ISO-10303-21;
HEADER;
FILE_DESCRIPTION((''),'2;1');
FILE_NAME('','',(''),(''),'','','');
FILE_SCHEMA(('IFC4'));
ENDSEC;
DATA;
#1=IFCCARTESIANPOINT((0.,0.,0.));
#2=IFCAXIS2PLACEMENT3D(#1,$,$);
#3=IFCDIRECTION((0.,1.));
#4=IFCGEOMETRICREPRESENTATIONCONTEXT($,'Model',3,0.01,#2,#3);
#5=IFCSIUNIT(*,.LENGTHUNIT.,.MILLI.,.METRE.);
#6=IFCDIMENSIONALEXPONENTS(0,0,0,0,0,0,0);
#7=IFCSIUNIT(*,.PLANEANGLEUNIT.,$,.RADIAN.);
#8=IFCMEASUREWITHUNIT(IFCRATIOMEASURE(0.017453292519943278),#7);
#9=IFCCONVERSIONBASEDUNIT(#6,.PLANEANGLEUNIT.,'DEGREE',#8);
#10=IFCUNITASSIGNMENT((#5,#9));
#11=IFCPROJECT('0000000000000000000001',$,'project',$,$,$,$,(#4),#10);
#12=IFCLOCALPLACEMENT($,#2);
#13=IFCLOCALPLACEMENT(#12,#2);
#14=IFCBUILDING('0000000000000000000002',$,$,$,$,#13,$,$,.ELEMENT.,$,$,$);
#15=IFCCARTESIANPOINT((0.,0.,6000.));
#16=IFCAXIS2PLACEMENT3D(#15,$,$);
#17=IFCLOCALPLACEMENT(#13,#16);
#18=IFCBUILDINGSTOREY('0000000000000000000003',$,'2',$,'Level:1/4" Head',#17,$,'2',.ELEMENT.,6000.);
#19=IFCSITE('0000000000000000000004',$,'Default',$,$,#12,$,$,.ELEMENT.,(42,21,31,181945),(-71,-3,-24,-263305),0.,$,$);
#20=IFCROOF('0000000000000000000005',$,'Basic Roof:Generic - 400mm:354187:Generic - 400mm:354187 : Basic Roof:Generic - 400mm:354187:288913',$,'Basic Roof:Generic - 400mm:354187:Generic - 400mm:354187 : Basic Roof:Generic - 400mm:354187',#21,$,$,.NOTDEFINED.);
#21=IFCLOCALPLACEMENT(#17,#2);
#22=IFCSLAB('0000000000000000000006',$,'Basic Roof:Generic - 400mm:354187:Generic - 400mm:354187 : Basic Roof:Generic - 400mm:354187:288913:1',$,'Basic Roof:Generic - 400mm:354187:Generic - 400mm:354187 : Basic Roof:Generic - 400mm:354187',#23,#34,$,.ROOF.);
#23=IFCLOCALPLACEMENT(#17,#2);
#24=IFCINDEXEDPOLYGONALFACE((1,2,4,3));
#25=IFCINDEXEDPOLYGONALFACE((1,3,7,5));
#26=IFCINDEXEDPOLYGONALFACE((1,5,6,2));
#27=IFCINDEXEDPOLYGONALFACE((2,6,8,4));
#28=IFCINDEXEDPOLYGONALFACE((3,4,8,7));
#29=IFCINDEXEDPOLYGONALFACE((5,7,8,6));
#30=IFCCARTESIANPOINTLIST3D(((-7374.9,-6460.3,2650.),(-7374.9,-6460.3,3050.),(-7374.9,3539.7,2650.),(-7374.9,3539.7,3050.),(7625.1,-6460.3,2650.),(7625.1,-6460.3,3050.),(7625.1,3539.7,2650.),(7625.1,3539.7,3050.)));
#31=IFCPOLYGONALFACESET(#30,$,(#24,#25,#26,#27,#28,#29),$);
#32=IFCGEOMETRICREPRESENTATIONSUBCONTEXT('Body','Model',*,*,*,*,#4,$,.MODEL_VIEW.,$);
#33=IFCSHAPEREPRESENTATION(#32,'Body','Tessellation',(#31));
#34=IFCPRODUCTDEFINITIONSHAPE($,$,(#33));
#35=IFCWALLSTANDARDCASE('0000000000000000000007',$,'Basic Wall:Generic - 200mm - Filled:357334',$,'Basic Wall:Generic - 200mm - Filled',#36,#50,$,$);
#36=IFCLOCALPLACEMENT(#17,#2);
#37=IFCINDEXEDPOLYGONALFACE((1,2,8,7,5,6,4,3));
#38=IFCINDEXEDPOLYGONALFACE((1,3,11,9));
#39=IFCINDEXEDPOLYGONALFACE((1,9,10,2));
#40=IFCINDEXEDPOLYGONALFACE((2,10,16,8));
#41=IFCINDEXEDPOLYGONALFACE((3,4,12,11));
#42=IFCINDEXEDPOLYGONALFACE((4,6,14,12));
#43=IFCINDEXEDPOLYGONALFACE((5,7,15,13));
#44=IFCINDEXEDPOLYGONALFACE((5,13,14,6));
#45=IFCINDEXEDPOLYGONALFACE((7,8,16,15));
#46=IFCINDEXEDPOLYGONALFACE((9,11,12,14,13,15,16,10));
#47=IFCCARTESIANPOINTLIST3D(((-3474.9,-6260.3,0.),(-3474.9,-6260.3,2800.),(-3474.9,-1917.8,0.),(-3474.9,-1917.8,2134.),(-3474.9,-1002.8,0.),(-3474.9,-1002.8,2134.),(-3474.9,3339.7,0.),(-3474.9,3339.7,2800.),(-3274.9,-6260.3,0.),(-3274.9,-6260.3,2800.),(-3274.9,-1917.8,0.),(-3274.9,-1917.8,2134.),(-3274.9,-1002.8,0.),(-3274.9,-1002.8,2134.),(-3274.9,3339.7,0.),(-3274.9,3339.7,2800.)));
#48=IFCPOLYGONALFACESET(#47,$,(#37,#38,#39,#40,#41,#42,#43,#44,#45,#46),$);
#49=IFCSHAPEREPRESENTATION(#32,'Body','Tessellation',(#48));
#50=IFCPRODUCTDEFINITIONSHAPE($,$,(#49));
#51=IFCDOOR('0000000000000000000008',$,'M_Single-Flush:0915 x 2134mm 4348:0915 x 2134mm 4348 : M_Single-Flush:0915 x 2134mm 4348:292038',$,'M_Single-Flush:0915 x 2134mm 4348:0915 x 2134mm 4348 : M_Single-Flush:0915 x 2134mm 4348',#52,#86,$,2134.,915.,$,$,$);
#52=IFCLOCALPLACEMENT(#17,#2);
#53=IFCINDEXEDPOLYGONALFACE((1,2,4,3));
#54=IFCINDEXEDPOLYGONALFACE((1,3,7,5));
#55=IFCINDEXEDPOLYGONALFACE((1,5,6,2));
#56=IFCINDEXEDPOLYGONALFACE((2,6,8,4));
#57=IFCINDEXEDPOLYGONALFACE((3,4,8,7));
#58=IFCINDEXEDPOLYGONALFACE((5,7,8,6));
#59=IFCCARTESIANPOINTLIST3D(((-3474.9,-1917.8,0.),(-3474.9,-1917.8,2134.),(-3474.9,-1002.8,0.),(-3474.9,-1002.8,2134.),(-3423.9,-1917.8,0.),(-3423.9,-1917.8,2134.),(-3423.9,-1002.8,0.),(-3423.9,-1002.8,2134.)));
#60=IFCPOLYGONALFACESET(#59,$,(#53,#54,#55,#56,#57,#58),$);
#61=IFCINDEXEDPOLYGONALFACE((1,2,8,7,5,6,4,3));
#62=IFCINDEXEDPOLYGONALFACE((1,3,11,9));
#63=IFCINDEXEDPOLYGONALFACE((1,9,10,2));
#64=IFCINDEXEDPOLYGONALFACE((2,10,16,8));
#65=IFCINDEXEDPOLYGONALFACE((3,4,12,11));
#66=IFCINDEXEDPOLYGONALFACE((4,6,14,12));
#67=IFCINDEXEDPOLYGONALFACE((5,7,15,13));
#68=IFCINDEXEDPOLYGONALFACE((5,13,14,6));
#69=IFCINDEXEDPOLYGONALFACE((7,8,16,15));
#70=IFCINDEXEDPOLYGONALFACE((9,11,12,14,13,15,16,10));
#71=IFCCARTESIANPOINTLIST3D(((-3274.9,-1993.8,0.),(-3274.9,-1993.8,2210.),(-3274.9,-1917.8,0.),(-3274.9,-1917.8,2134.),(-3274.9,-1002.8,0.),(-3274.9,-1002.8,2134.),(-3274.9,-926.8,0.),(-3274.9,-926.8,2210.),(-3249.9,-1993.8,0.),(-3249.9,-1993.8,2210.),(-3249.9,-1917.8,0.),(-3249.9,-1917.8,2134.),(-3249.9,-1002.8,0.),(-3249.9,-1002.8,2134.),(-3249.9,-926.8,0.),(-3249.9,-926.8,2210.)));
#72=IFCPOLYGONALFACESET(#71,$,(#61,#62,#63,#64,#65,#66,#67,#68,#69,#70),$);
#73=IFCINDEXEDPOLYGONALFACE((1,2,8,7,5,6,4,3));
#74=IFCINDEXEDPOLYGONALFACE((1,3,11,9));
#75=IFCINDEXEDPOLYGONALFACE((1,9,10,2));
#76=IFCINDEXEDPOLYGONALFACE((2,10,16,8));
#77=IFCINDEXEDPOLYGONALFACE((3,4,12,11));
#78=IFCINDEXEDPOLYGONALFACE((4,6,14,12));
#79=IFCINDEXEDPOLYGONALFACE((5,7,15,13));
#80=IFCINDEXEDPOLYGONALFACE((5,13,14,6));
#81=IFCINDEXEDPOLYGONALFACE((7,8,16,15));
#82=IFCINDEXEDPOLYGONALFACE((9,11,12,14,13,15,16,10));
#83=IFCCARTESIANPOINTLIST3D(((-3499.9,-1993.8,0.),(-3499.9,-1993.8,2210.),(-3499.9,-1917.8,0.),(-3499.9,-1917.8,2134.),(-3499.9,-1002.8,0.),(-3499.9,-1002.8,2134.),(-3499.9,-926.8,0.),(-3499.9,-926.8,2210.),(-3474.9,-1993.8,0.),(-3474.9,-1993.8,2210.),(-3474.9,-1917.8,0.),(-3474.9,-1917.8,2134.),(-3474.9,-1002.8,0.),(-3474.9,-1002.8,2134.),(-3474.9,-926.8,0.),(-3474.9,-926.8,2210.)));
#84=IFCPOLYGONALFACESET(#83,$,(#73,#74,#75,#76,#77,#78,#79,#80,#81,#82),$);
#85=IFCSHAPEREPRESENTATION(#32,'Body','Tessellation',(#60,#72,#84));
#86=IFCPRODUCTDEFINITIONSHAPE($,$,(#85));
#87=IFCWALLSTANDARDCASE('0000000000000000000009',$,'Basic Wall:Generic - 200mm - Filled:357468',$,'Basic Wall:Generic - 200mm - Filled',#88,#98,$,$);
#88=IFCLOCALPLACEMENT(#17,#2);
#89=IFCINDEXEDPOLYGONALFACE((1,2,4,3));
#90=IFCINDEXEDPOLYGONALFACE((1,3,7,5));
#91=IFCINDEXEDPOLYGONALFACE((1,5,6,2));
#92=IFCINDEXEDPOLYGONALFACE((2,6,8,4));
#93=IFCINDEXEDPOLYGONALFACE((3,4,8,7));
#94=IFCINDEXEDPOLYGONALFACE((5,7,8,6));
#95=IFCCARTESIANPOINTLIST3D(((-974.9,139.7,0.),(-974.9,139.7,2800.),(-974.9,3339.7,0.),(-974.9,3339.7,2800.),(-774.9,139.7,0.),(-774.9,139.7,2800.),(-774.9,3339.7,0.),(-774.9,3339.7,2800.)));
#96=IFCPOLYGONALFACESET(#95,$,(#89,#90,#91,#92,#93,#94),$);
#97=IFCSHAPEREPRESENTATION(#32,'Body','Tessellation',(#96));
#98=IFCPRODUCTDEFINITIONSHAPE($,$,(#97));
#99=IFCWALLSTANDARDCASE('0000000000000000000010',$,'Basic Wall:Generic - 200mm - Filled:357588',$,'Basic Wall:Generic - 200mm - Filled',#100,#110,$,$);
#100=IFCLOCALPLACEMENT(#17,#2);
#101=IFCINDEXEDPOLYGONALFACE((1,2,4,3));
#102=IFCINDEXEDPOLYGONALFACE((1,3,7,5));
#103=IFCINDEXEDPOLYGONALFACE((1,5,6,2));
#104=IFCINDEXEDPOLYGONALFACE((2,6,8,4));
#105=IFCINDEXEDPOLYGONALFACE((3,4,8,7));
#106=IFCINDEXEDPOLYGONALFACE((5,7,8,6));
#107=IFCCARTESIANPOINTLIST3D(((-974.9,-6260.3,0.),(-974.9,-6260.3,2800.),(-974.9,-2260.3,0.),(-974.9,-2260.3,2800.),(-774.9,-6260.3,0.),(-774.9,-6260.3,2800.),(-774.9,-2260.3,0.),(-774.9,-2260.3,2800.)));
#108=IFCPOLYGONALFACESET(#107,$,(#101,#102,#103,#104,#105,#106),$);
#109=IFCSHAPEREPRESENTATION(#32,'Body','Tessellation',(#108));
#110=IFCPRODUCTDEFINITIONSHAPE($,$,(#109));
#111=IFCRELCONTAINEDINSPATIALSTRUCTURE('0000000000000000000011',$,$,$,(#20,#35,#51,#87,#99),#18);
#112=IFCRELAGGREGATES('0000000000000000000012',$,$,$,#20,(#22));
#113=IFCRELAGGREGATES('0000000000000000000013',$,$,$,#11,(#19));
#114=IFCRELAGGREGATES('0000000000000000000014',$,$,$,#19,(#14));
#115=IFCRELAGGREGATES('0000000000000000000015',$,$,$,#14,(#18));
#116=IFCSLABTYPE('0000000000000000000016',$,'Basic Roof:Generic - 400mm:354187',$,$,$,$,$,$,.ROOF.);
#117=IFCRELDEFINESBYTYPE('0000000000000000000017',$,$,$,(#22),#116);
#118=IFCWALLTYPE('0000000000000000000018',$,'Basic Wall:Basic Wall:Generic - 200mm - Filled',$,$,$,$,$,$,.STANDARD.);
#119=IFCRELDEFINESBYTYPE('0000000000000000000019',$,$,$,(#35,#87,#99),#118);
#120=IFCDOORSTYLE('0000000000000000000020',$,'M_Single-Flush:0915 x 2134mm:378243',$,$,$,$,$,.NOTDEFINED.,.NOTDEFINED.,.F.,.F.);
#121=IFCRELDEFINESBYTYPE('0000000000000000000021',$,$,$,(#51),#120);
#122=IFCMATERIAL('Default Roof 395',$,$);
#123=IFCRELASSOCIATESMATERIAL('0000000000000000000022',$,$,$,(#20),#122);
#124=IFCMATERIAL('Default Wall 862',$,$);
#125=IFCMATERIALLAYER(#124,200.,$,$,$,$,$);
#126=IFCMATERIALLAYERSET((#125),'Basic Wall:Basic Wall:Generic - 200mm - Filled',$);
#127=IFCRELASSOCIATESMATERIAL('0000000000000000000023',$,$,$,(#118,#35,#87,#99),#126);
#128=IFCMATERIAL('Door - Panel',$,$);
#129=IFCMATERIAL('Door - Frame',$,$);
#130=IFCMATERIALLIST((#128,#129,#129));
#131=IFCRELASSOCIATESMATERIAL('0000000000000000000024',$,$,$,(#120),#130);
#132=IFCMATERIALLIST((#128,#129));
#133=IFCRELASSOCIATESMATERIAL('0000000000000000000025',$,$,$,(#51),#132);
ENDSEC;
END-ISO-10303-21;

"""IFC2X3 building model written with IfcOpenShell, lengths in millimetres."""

from ifc_helpers import new_model, entity, si_unit, converted_unit, direction, frame, frame_2d, origin, origin_2d_with_axis, place, context, subcontext, project, spatial, polyline, rectangle, outline, extrude, source, transform, mapped, material, material_list, layer, layer_set, layer_usage, type_object, type_shapes, element, fill, aggregate, save


model = new_model("IFC2X3")

# Units and contexts
model_context = context("Model", 3, precision=0.01, world=origin(), true_north=direction((0.0, 1.0)))
body_context = subcontext(model_context, "Body", "Model", "MODEL_VIEW")
ifc_project = project(units=[si_unit("LENGTHUNIT", "METRE", prefix="MILLI"), converted_unit("PLANEANGLEUNIT", "DEGREE", entity("IfcRatioMeasure", 0.017453292519943278), si_unit("PLANEANGLEUNIT", "RADIAN"), dimensions=[0, 0, 0, 0, 0, 0, 0])], contexts=[model_context])

# Site, building, storey
site_placement = place(None, origin())
site = spatial("IfcSite", under=ifc_project, at=site_placement, Name="Default", CompositionType="ELEMENT", RefLatitude=(42, 21, 31, 181945), RefLongitude=(-71, -3, -24, -263305), RefElevation=0.0)
building_placement = place(site_placement, origin())
building = spatial("IfcBuilding", under=site, at=building_placement, CompositionType="ELEMENT")
storey_placement = place(building_placement, frame((0.0, 0.0, 6000.0)))
storey = spatial("IfcBuildingStorey", under=building, at=storey_placement, Name="2", ObjectType="Level:1/4\" Head", LongName="2", CompositionType="ELEMENT", Elevation=6000.0)

# Roof, slab
ifc_material_1 = material(Name="Default Roof 395")
roof_placement = place(storey_placement, origin())
roof = element("IfcRoof", 1, at=roof_placement, inside=storey, material=ifc_material_1, Name="Basic Roof:Generic - 400mm:354187:Generic - 400mm:354187 : Basic Roof:Generic - 400mm:354187:288913", ObjectType="Basic Roof:Generic - 400mm:354187:Generic - 400mm:354187 : Basic Roof:Generic - 400mm:354187", ShapeType="NOTDEFINED")
slab_type_1 = type_object("IfcSlabType", Name="Basic Roof:Generic - 400mm:354187", PredefinedType="ROOF")
slab_1_placement = place(storey_placement, origin())
slab_1 = element("IfcSlab", 2, at=slab_1_placement, type_object=slab_type_1, Name="Basic Roof:Generic - 400mm:354187:Generic - 400mm:354187 : Basic Roof:Generic - 400mm:354187:288913:1", ObjectType="Basic Roof:Generic - 400mm:354187:Generic - 400mm:354187 : Basic Roof:Generic - 400mm:354187", PredefinedType="ROOF", context=body_context, shape_type="SweptSolid", body=[
    extrude(rectangle(XDim=10000.0, YDim=15000.0, at=origin_2d_with_axis()), frame((125.1, -1460.3, 2650.0), z_axis=(0.0, 0.0, 1.0), x_axis=(0.0, 1.0, 0.0)), (0.0, 0.0, 1.0), 400.0),
])
aggregate(roof, [slab_1])

# Wall, opening, door
ifc_material_2 = material(Name="Default Wall 862")
ifc_layer_1 = layer(ifc_material_2, 200.0)
ifc_layer_set_1 = layer_set([ifc_layer_1], Name="Basic Wall:Basic Wall:Generic - 200mm - Filled")
ifc_layer_usage_1 = layer_usage(ifc_layer_set_1, "AXIS2", "NEGATIVE", 100.0)
wall_type_1 = type_object("IfcWallType", Name="Basic Wall:Basic Wall:Generic - 200mm - Filled", PredefinedType="STANDARD", material=ifc_layer_set_1)
wall_1_placement = place(storey_placement, frame((-3374.9, 3339.7, 0.0), z_axis=(0.0, 0.0, 1.0), x_axis=(0.0, -1.0, 0.0)))
wall_1 = element("IfcWallStandardCase", 3, at=wall_1_placement, inside=storey, type_object=wall_type_1, material=ifc_layer_usage_1, Name="Basic Wall:Generic - 200mm - Filled:357334", ObjectType="Basic Wall:Generic - 200mm - Filled", context=body_context, shape_type="SweptSolid", body=[
    extrude(rectangle(XDim=9600.0, YDim=200.0, at=frame_2d((4800.0, 0.0), x_axis=(1.0, 0.0))), origin(), (0.0, 0.0, 1.0), 2800.0),
])
opening_1_placement = place(wall_1_placement, frame((3339.7, 3374.9, 0.0), z_axis=(0.0, 0.0, 1.0), x_axis=(0.0, 1.0, 0.0)))
opening_1 = element("IfcOpeningElement", 4, at=opening_1_placement, cuts=wall_1, ObjectType="Opening", context=body_context, shape_type="SweptSolid", body=[
    extrude(rectangle(XDim=2134.0, YDim=915.0, at=frame_2d((0.0, 0.0), x_axis=(0.0, 1.0))), frame((-3476.9, -1460.3, 1067.0), z_axis=(1.0, 0.0, 0.0), x_axis=(0.0, -1.0, 0.0)), (0.0, 0.0, 1.0), 204.0),
])
ifc_material_3 = material(Name="Door - Panel")
ifc_material_4 = material(Name="Door - Frame")
ifc_material_list_1 = material_list([ifc_material_3, ifc_material_4])
ifc_material_list_2 = material_list([ifc_material_3, ifc_material_4, ifc_material_4])
door_style_1 = type_object("IfcDoorStyle", Name="M_Single-Flush:0915 x 2134mm:378243", ConstructionType="NOTDEFINED", OperationType="NOTDEFINED", ParameterTakesPrecedence=False, Sizeable=False, material=ifc_material_list_2)
shared_shape_1 = source(origin(), body_context, "Body", "SweptSolid", [
    extrude(rectangle(XDim=915.0, YDim=51.0, at=origin_2d_with_axis()), frame((457.5, 176.5, 0.0), z_axis=(0.0, 0.0, 1.0), x_axis=(-1.0, 0.0, 0.0)), (0.0, 0.0, 1.0), 2134.0),
    extrude(outline(polyline([(-533.5, -1086.0), (-457.5, -1086.0), (-457.5, 1048.0), (457.5, 1048.0), (457.5, -1086.0), (533.5, -1086.0), (533.5, 1124.0), (-533.5, 1124.0), (-533.5, -1086.0)])), frame((457.5, -23.0, 1086.0), z_axis=(0.0, 1.0, 0.0), x_axis=(-1.0, 0.0, 0.0)), (0.0, 0.0, 1.0), 25.0),
    extrude(outline(polyline([(-1124.0, -533.5), (1086.0, -533.5), (1086.0, -457.5), (-1048.0, -457.5), (-1048.0, 457.5), (1086.0, 457.5), (1086.0, 533.5), (-1124.0, 533.5), (-1124.0, -533.5)])), frame((457.5, 202.0, 1086.0), z_axis=(0.0, 1.0, 0.0), x_axis=(0.0, 0.0, -1.0)), (0.0, 0.0, 1.0), 25.0),
])
type_shapes(door_style_1, [shared_shape_1])
door_1_placement = place(opening_1_placement, frame((-3272.9, -1917.8, 0.0), z_axis=(0.0, 0.0, 1.0), x_axis=(0.0, 1.0, 0.0)))
door_1 = element("IfcDoor", 5, at=door_1_placement, inside=storey, type_object=door_style_1, material=ifc_material_list_1, Name="M_Single-Flush:0915 x 2134mm 4348:0915 x 2134mm 4348 : M_Single-Flush:0915 x 2134mm 4348:292038", ObjectType="M_Single-Flush:0915 x 2134mm 4348:0915 x 2134mm 4348 : M_Single-Flush:0915 x 2134mm 4348", OverallHeight=2134.0, OverallWidth=915.0, context=body_context, shape_type="MappedRepresentation", body=[
    mapped(shared_shape_1, transform((0.0, 0.0, 0.0), scale=1.0)),
])
fill(opening_1, door_1)

# Walls
ifc_layer_usage_2 = layer_usage(ifc_layer_set_1, "AXIS2", "NEGATIVE", 100.0)
wall_2_placement = place(storey_placement, frame((-874.9, 3339.7, 0.0), z_axis=(0.0, 0.0, 1.0), x_axis=(0.0, -1.0, 0.0)))
element("IfcWallStandardCase", 6, at=wall_2_placement, inside=storey, type_object=wall_type_1, material=ifc_layer_usage_2, Name="Basic Wall:Generic - 200mm - Filled:357468", ObjectType="Basic Wall:Generic - 200mm - Filled", context=body_context, shape_type="SweptSolid", body=[
    extrude(rectangle(XDim=3200.0, YDim=200.0, at=frame_2d((1600.0, 0.0), x_axis=(-1.0, 0.0))), origin(), (0.0, 0.0, 1.0), 2800.0),
])
ifc_layer_usage_3 = layer_usage(ifc_layer_set_1, "AXIS2", "NEGATIVE", 100.0)
wall_3_placement = place(storey_placement, frame((-874.9, -2260.3, 0.0), z_axis=(0.0, 0.0, 1.0), x_axis=(0.0, -1.0, 0.0)))
element("IfcWallStandardCase", 7, at=wall_3_placement, inside=storey, type_object=wall_type_1, material=ifc_layer_usage_3, Name="Basic Wall:Generic - 200mm - Filled:357588", ObjectType="Basic Wall:Generic - 200mm - Filled", context=body_context, shape_type="SweptSolid", body=[
    extrude(rectangle(XDim=4000.0, YDim=200.0, at=frame_2d((2000.0, 0.0), x_axis=(-1.0, 0.0))), origin(), (0.0, 0.0, 1.0), 2800.0),
])

save(model, "model.ifc")
